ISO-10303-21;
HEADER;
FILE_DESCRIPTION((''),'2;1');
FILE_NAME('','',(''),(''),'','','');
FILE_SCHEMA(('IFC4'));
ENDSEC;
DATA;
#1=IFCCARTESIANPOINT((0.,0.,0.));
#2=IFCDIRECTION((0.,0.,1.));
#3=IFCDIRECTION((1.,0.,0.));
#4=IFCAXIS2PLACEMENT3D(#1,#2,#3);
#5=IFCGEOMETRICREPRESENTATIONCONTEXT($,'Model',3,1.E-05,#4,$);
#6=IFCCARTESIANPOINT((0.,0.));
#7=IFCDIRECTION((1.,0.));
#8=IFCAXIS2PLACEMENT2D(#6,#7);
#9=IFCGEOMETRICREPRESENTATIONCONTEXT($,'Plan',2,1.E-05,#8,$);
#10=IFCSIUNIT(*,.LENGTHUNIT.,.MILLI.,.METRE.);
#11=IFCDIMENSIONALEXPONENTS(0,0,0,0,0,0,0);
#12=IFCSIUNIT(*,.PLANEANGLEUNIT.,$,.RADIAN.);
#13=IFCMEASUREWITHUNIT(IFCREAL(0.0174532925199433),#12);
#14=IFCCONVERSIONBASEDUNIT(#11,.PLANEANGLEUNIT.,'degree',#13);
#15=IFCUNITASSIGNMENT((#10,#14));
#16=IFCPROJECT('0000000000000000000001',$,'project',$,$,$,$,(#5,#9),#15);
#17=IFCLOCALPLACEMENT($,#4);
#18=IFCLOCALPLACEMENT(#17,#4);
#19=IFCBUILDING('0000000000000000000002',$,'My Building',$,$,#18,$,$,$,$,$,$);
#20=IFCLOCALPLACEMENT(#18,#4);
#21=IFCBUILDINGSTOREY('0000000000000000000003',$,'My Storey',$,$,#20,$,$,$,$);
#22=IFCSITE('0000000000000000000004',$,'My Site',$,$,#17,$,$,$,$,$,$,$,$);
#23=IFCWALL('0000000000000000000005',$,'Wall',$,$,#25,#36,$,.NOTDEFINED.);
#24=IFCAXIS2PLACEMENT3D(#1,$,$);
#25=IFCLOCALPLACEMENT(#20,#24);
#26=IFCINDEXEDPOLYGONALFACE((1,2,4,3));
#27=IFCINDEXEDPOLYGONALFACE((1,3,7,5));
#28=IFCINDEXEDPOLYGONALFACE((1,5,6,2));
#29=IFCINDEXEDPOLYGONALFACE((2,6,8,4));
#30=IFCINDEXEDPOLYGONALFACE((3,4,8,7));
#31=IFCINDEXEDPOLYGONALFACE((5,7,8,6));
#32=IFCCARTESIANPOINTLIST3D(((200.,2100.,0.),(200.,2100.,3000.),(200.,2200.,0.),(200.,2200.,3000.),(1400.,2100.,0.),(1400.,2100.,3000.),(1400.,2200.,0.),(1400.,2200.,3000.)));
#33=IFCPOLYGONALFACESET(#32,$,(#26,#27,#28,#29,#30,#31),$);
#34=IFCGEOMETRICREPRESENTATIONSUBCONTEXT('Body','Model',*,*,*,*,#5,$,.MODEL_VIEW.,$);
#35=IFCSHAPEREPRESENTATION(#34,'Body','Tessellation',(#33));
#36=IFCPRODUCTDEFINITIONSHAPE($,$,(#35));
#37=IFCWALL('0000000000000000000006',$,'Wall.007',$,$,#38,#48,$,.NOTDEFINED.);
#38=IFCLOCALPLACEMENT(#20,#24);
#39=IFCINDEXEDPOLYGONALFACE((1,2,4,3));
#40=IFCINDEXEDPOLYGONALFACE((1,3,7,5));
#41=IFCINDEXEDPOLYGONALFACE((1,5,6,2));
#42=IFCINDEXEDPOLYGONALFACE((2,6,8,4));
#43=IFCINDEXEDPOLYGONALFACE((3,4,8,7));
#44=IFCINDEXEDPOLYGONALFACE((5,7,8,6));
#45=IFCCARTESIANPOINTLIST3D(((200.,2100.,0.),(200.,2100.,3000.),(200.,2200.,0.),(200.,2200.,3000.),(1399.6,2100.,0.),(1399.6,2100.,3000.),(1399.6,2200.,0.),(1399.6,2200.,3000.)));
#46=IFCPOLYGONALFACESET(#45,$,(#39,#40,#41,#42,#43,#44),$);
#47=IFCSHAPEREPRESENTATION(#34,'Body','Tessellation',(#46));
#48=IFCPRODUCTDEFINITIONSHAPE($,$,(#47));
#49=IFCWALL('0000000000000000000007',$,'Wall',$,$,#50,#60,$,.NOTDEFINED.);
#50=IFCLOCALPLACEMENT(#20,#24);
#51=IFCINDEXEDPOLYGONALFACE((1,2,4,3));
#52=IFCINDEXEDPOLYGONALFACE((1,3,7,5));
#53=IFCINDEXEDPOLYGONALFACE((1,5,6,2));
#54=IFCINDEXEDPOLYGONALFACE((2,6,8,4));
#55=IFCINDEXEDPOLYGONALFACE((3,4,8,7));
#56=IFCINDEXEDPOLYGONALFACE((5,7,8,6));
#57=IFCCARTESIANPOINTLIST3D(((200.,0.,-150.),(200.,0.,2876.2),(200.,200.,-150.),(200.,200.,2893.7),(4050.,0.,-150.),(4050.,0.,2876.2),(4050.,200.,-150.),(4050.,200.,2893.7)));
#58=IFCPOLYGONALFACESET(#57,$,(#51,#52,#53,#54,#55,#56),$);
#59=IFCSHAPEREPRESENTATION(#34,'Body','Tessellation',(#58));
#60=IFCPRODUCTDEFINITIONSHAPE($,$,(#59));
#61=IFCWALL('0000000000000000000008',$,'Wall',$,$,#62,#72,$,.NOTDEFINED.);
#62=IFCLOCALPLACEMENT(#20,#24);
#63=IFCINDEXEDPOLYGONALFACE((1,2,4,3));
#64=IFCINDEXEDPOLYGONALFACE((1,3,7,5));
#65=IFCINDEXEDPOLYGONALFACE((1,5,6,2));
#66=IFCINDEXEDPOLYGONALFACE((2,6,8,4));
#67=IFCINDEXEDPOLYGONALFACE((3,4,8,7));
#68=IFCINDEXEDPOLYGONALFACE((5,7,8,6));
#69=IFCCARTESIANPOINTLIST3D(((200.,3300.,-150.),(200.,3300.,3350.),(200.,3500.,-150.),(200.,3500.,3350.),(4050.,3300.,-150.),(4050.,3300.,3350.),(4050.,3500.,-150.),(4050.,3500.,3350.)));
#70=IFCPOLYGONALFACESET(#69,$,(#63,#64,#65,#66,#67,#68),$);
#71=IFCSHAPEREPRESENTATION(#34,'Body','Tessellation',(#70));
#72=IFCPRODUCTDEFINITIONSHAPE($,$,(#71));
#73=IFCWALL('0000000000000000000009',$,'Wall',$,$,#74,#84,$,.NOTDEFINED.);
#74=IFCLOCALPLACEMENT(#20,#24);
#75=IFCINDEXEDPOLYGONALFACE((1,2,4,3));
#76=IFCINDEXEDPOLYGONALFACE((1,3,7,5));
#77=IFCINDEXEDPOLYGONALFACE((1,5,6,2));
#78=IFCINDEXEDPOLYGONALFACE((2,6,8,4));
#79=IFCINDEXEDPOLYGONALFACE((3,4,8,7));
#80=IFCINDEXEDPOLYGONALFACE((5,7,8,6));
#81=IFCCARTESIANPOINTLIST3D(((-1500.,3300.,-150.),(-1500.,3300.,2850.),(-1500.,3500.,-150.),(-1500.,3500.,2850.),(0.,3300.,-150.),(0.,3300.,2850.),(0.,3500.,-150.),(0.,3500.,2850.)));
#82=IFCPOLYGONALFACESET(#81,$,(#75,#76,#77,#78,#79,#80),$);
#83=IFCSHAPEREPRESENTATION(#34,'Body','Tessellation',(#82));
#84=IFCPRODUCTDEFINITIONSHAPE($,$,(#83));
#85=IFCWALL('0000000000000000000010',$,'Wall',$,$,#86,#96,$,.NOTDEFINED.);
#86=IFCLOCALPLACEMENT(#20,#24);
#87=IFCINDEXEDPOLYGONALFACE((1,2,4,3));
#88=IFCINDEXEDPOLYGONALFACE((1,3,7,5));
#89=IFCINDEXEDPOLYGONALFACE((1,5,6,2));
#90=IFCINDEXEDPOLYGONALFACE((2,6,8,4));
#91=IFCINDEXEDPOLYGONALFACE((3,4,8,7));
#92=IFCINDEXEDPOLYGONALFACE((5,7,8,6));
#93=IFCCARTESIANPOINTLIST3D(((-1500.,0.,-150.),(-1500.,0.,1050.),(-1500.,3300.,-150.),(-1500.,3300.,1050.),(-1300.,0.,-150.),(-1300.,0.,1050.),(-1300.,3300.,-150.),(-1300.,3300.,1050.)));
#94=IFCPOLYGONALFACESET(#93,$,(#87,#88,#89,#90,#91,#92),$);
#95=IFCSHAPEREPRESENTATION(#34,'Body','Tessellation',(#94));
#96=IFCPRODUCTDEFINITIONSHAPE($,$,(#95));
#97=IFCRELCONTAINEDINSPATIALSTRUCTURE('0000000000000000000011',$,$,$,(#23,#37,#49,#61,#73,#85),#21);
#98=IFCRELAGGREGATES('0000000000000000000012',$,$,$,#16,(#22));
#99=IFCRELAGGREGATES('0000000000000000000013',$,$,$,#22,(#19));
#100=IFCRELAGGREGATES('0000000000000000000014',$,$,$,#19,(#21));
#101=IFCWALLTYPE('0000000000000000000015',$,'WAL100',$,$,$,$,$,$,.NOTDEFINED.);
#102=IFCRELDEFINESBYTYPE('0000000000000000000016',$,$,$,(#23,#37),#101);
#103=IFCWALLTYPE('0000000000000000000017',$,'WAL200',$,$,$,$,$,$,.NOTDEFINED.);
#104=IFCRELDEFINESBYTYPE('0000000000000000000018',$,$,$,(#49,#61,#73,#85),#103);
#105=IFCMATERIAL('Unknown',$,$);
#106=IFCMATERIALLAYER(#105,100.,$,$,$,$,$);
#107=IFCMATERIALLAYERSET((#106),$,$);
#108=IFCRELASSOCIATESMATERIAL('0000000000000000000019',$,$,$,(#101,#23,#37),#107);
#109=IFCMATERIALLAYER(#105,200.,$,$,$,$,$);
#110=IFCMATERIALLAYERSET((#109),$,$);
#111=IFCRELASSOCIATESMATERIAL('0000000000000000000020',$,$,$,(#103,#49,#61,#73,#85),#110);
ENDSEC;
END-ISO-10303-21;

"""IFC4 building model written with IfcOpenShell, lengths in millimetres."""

from ifc_helpers import new_model, entity, si_unit, converted_unit, frame, origin_with_axes, origin_2d_with_axis, place, context, subcontext, project, spatial, indexed_curve, outline, extrude, clip, halfspace, material, layer, layer_set, layer_usage, type_object, element, save


model = new_model("IFC4")

# Units and contexts
model_context = context("Model", 3, precision=1e-05, world=origin_with_axes())
plan_context = context("Plan", 2, precision=1e-05, world=origin_2d_with_axis())
body_context = subcontext(model_context, "Body", "Model", "MODEL_VIEW")
ifc_project = project(units=[si_unit("LENGTHUNIT", "METRE", prefix="MILLI"), converted_unit("PLANEANGLEUNIT", "degree", entity("IfcReal", 0.0174532925199433), si_unit("PLANEANGLEUNIT", "RADIAN"), dimensions=[0, 0, 0, 0, 0, 0, 0])], contexts=[model_context, plan_context])

# Site, building, storey
site_placement = place(None, origin_with_axes())
site = spatial("IfcSite", under=ifc_project, at=site_placement, Name="My Site")
building_placement = place(site_placement, origin_with_axes())
building = spatial("IfcBuilding", under=site, at=building_placement, Name="My Building")
storey_placement = place(building_placement, origin_with_axes())
storey = spatial("IfcBuildingStorey", under=building, at=storey_placement, Name="My Storey")

# Shared definitions
ifc_material = material(Name="Unknown")

# Walls
ifc_layer_1 = layer(ifc_material, 100.0)
ifc_layer_set_1 = layer_set([ifc_layer_1])
ifc_layer_usage_1 = layer_usage(ifc_layer_set_1, "AXIS2", "POSITIVE", 0.0)
wall_type_1 = type_object("IfcWallType", Name="WAL100", PredefinedType="NOTDEFINED", material=ifc_layer_set_1)
wall_1_placement = place(storey_placement, frame((200.0, 2100.0, 0.0), z_axis=(0.0, 0.0, 1.0), x_axis=(1.0, 0.0, 0.0)))
element("IfcWall", 1, at=wall_1_placement, inside=storey, type_object=wall_type_1, material=ifc_layer_usage_1, Name="Wall", PredefinedType="NOTDEFINED", context=body_context, shape_type="SweptSolid", body=[
    extrude(outline(indexed_curve([(0.0, 0.0), (0.0, 100.0), (1200.0, 100.0), (1200.0, 0.0), (0.0, 0.0)], self_intersect=False)), origin_with_axes(), (0.0, 0.0, 1.0), 3000.0),
])
ifc_layer_usage_2 = layer_usage(ifc_layer_set_1, "AXIS2", "POSITIVE", 0.0)
wall_2_placement = place(storey_placement, frame((1399.6, 2200.0, 0.0), z_axis=(0.0, 0.0, 1.0), x_axis=(-1.0, 0.0, 0.0)))
element("IfcWall", 2, at=wall_2_placement, inside=storey, type_object=wall_type_1, material=ifc_layer_usage_2, Name="Wall.007", PredefinedType="NOTDEFINED", context=body_context, shape_type="SweptSolid", body=[
    extrude(outline(indexed_curve([(0.0, 0.0), (0.0, 100.0), (1199.6, 100.0), (1199.6, 0.0), (0.0, 0.0)], self_intersect=False)), origin_with_axes(), (0.0, 0.0, 1.0), 3000.0),
])
ifc_layer_2 = layer(ifc_material, 200.0)
ifc_layer_set_2 = layer_set([ifc_layer_2])
ifc_layer_usage_3 = layer_usage(ifc_layer_set_2, "AXIS2", "POSITIVE", 0.0)
wall_type_2 = type_object("IfcWallType", Name="WAL200", PredefinedType="NOTDEFINED", material=ifc_layer_set_2)
wall_3_placement = place(storey_placement, frame((200.0, 0.0, -150.0), z_axis=(0.0, 0.0, 1.0), x_axis=(1.0, 0.0, 0.0)))
element("IfcWall", 3, at=wall_3_placement, inside=storey, type_object=wall_type_2, material=ifc_layer_usage_3, Name="Wall", PredefinedType="NOTDEFINED", context=body_context, shape_type="Clipping", body=[
    clip(extrude(outline(indexed_curve([(0.0, 0.0), (0.0, 200.0), (3850.0, 200.0), (3850.0, 0.0), (0.0, 0.0)], self_intersect=False)), origin_with_axes(), (0.0, 0.0, 1.0), 3043.7), halfspace(frame((0.0, 200.0, 3043.7), z_axis=(0.0, -0.087156, 0.996195), x_axis=(1.0, 0.0, 0.0)), False)),
])
ifc_layer_usage_4 = layer_usage(ifc_layer_set_2, "AXIS2", "POSITIVE", 0.0)
wall_4_placement = place(storey_placement, frame((4050.0, 3500.0, -150.0), z_axis=(0.0, 0.0, 1.0), x_axis=(-1.0, 0.0, 0.0)))
element("IfcWall", 4, at=wall_4_placement, inside=storey, type_object=wall_type_2, material=ifc_layer_usage_4, Name="Wall", PredefinedType="NOTDEFINED", context=body_context, shape_type="SweptSolid", body=[
    extrude(outline(indexed_curve([(0.0, 0.0), (0.0, 200.0), (3850.0, 200.0), (3850.0, 0.0), (0.0, 0.0)], self_intersect=False)), origin_with_axes(), (0.0, 0.0, 1.0), 3500.0),
])
ifc_layer_usage_5 = layer_usage(ifc_layer_set_2, "AXIS2", "POSITIVE", 0.0)
wall_5_placement = place(storey_placement, frame((0.0, 3500.0, -150.0), z_axis=(0.0, 0.0, 1.0), x_axis=(-1.0, 0.0, 0.0)))
element("IfcWall", 5, at=wall_5_placement, inside=storey, type_object=wall_type_2, material=ifc_layer_usage_5, Name="Wall", PredefinedType="NOTDEFINED", context=body_context, shape_type="SweptSolid", body=[
    extrude(outline(indexed_curve([(0.0, 0.0), (0.0, 200.0), (1500.0, 200.0), (1500.0, 0.0), (0.0, 0.0)], self_intersect=False)), origin_with_axes(), (0.0, 0.0, 1.0), 3000.0),
])
ifc_layer_usage_6 = layer_usage(ifc_layer_set_2, "AXIS2", "POSITIVE", 0.0)
wall_6_placement = place(storey_placement, frame((-1500.0, 3300.0, -150.0), z_axis=(0.0, 0.0, 1.0), x_axis=(0.0, -1.0, 0.0)))
element("IfcWall", 6, at=wall_6_placement, inside=storey, type_object=wall_type_2, material=ifc_layer_usage_6, Name="Wall", PredefinedType="NOTDEFINED", context=body_context, shape_type="SweptSolid", body=[
    extrude(outline(indexed_curve([(0.0, 0.0), (0.0, 200.0), (3300.0, 200.0), (3300.0, 0.0), (0.0, 0.0)], self_intersect=False)), origin_with_axes(), (0.0, 0.0, 1.0), 1200.0),
])

save(model, "model.ifc")
